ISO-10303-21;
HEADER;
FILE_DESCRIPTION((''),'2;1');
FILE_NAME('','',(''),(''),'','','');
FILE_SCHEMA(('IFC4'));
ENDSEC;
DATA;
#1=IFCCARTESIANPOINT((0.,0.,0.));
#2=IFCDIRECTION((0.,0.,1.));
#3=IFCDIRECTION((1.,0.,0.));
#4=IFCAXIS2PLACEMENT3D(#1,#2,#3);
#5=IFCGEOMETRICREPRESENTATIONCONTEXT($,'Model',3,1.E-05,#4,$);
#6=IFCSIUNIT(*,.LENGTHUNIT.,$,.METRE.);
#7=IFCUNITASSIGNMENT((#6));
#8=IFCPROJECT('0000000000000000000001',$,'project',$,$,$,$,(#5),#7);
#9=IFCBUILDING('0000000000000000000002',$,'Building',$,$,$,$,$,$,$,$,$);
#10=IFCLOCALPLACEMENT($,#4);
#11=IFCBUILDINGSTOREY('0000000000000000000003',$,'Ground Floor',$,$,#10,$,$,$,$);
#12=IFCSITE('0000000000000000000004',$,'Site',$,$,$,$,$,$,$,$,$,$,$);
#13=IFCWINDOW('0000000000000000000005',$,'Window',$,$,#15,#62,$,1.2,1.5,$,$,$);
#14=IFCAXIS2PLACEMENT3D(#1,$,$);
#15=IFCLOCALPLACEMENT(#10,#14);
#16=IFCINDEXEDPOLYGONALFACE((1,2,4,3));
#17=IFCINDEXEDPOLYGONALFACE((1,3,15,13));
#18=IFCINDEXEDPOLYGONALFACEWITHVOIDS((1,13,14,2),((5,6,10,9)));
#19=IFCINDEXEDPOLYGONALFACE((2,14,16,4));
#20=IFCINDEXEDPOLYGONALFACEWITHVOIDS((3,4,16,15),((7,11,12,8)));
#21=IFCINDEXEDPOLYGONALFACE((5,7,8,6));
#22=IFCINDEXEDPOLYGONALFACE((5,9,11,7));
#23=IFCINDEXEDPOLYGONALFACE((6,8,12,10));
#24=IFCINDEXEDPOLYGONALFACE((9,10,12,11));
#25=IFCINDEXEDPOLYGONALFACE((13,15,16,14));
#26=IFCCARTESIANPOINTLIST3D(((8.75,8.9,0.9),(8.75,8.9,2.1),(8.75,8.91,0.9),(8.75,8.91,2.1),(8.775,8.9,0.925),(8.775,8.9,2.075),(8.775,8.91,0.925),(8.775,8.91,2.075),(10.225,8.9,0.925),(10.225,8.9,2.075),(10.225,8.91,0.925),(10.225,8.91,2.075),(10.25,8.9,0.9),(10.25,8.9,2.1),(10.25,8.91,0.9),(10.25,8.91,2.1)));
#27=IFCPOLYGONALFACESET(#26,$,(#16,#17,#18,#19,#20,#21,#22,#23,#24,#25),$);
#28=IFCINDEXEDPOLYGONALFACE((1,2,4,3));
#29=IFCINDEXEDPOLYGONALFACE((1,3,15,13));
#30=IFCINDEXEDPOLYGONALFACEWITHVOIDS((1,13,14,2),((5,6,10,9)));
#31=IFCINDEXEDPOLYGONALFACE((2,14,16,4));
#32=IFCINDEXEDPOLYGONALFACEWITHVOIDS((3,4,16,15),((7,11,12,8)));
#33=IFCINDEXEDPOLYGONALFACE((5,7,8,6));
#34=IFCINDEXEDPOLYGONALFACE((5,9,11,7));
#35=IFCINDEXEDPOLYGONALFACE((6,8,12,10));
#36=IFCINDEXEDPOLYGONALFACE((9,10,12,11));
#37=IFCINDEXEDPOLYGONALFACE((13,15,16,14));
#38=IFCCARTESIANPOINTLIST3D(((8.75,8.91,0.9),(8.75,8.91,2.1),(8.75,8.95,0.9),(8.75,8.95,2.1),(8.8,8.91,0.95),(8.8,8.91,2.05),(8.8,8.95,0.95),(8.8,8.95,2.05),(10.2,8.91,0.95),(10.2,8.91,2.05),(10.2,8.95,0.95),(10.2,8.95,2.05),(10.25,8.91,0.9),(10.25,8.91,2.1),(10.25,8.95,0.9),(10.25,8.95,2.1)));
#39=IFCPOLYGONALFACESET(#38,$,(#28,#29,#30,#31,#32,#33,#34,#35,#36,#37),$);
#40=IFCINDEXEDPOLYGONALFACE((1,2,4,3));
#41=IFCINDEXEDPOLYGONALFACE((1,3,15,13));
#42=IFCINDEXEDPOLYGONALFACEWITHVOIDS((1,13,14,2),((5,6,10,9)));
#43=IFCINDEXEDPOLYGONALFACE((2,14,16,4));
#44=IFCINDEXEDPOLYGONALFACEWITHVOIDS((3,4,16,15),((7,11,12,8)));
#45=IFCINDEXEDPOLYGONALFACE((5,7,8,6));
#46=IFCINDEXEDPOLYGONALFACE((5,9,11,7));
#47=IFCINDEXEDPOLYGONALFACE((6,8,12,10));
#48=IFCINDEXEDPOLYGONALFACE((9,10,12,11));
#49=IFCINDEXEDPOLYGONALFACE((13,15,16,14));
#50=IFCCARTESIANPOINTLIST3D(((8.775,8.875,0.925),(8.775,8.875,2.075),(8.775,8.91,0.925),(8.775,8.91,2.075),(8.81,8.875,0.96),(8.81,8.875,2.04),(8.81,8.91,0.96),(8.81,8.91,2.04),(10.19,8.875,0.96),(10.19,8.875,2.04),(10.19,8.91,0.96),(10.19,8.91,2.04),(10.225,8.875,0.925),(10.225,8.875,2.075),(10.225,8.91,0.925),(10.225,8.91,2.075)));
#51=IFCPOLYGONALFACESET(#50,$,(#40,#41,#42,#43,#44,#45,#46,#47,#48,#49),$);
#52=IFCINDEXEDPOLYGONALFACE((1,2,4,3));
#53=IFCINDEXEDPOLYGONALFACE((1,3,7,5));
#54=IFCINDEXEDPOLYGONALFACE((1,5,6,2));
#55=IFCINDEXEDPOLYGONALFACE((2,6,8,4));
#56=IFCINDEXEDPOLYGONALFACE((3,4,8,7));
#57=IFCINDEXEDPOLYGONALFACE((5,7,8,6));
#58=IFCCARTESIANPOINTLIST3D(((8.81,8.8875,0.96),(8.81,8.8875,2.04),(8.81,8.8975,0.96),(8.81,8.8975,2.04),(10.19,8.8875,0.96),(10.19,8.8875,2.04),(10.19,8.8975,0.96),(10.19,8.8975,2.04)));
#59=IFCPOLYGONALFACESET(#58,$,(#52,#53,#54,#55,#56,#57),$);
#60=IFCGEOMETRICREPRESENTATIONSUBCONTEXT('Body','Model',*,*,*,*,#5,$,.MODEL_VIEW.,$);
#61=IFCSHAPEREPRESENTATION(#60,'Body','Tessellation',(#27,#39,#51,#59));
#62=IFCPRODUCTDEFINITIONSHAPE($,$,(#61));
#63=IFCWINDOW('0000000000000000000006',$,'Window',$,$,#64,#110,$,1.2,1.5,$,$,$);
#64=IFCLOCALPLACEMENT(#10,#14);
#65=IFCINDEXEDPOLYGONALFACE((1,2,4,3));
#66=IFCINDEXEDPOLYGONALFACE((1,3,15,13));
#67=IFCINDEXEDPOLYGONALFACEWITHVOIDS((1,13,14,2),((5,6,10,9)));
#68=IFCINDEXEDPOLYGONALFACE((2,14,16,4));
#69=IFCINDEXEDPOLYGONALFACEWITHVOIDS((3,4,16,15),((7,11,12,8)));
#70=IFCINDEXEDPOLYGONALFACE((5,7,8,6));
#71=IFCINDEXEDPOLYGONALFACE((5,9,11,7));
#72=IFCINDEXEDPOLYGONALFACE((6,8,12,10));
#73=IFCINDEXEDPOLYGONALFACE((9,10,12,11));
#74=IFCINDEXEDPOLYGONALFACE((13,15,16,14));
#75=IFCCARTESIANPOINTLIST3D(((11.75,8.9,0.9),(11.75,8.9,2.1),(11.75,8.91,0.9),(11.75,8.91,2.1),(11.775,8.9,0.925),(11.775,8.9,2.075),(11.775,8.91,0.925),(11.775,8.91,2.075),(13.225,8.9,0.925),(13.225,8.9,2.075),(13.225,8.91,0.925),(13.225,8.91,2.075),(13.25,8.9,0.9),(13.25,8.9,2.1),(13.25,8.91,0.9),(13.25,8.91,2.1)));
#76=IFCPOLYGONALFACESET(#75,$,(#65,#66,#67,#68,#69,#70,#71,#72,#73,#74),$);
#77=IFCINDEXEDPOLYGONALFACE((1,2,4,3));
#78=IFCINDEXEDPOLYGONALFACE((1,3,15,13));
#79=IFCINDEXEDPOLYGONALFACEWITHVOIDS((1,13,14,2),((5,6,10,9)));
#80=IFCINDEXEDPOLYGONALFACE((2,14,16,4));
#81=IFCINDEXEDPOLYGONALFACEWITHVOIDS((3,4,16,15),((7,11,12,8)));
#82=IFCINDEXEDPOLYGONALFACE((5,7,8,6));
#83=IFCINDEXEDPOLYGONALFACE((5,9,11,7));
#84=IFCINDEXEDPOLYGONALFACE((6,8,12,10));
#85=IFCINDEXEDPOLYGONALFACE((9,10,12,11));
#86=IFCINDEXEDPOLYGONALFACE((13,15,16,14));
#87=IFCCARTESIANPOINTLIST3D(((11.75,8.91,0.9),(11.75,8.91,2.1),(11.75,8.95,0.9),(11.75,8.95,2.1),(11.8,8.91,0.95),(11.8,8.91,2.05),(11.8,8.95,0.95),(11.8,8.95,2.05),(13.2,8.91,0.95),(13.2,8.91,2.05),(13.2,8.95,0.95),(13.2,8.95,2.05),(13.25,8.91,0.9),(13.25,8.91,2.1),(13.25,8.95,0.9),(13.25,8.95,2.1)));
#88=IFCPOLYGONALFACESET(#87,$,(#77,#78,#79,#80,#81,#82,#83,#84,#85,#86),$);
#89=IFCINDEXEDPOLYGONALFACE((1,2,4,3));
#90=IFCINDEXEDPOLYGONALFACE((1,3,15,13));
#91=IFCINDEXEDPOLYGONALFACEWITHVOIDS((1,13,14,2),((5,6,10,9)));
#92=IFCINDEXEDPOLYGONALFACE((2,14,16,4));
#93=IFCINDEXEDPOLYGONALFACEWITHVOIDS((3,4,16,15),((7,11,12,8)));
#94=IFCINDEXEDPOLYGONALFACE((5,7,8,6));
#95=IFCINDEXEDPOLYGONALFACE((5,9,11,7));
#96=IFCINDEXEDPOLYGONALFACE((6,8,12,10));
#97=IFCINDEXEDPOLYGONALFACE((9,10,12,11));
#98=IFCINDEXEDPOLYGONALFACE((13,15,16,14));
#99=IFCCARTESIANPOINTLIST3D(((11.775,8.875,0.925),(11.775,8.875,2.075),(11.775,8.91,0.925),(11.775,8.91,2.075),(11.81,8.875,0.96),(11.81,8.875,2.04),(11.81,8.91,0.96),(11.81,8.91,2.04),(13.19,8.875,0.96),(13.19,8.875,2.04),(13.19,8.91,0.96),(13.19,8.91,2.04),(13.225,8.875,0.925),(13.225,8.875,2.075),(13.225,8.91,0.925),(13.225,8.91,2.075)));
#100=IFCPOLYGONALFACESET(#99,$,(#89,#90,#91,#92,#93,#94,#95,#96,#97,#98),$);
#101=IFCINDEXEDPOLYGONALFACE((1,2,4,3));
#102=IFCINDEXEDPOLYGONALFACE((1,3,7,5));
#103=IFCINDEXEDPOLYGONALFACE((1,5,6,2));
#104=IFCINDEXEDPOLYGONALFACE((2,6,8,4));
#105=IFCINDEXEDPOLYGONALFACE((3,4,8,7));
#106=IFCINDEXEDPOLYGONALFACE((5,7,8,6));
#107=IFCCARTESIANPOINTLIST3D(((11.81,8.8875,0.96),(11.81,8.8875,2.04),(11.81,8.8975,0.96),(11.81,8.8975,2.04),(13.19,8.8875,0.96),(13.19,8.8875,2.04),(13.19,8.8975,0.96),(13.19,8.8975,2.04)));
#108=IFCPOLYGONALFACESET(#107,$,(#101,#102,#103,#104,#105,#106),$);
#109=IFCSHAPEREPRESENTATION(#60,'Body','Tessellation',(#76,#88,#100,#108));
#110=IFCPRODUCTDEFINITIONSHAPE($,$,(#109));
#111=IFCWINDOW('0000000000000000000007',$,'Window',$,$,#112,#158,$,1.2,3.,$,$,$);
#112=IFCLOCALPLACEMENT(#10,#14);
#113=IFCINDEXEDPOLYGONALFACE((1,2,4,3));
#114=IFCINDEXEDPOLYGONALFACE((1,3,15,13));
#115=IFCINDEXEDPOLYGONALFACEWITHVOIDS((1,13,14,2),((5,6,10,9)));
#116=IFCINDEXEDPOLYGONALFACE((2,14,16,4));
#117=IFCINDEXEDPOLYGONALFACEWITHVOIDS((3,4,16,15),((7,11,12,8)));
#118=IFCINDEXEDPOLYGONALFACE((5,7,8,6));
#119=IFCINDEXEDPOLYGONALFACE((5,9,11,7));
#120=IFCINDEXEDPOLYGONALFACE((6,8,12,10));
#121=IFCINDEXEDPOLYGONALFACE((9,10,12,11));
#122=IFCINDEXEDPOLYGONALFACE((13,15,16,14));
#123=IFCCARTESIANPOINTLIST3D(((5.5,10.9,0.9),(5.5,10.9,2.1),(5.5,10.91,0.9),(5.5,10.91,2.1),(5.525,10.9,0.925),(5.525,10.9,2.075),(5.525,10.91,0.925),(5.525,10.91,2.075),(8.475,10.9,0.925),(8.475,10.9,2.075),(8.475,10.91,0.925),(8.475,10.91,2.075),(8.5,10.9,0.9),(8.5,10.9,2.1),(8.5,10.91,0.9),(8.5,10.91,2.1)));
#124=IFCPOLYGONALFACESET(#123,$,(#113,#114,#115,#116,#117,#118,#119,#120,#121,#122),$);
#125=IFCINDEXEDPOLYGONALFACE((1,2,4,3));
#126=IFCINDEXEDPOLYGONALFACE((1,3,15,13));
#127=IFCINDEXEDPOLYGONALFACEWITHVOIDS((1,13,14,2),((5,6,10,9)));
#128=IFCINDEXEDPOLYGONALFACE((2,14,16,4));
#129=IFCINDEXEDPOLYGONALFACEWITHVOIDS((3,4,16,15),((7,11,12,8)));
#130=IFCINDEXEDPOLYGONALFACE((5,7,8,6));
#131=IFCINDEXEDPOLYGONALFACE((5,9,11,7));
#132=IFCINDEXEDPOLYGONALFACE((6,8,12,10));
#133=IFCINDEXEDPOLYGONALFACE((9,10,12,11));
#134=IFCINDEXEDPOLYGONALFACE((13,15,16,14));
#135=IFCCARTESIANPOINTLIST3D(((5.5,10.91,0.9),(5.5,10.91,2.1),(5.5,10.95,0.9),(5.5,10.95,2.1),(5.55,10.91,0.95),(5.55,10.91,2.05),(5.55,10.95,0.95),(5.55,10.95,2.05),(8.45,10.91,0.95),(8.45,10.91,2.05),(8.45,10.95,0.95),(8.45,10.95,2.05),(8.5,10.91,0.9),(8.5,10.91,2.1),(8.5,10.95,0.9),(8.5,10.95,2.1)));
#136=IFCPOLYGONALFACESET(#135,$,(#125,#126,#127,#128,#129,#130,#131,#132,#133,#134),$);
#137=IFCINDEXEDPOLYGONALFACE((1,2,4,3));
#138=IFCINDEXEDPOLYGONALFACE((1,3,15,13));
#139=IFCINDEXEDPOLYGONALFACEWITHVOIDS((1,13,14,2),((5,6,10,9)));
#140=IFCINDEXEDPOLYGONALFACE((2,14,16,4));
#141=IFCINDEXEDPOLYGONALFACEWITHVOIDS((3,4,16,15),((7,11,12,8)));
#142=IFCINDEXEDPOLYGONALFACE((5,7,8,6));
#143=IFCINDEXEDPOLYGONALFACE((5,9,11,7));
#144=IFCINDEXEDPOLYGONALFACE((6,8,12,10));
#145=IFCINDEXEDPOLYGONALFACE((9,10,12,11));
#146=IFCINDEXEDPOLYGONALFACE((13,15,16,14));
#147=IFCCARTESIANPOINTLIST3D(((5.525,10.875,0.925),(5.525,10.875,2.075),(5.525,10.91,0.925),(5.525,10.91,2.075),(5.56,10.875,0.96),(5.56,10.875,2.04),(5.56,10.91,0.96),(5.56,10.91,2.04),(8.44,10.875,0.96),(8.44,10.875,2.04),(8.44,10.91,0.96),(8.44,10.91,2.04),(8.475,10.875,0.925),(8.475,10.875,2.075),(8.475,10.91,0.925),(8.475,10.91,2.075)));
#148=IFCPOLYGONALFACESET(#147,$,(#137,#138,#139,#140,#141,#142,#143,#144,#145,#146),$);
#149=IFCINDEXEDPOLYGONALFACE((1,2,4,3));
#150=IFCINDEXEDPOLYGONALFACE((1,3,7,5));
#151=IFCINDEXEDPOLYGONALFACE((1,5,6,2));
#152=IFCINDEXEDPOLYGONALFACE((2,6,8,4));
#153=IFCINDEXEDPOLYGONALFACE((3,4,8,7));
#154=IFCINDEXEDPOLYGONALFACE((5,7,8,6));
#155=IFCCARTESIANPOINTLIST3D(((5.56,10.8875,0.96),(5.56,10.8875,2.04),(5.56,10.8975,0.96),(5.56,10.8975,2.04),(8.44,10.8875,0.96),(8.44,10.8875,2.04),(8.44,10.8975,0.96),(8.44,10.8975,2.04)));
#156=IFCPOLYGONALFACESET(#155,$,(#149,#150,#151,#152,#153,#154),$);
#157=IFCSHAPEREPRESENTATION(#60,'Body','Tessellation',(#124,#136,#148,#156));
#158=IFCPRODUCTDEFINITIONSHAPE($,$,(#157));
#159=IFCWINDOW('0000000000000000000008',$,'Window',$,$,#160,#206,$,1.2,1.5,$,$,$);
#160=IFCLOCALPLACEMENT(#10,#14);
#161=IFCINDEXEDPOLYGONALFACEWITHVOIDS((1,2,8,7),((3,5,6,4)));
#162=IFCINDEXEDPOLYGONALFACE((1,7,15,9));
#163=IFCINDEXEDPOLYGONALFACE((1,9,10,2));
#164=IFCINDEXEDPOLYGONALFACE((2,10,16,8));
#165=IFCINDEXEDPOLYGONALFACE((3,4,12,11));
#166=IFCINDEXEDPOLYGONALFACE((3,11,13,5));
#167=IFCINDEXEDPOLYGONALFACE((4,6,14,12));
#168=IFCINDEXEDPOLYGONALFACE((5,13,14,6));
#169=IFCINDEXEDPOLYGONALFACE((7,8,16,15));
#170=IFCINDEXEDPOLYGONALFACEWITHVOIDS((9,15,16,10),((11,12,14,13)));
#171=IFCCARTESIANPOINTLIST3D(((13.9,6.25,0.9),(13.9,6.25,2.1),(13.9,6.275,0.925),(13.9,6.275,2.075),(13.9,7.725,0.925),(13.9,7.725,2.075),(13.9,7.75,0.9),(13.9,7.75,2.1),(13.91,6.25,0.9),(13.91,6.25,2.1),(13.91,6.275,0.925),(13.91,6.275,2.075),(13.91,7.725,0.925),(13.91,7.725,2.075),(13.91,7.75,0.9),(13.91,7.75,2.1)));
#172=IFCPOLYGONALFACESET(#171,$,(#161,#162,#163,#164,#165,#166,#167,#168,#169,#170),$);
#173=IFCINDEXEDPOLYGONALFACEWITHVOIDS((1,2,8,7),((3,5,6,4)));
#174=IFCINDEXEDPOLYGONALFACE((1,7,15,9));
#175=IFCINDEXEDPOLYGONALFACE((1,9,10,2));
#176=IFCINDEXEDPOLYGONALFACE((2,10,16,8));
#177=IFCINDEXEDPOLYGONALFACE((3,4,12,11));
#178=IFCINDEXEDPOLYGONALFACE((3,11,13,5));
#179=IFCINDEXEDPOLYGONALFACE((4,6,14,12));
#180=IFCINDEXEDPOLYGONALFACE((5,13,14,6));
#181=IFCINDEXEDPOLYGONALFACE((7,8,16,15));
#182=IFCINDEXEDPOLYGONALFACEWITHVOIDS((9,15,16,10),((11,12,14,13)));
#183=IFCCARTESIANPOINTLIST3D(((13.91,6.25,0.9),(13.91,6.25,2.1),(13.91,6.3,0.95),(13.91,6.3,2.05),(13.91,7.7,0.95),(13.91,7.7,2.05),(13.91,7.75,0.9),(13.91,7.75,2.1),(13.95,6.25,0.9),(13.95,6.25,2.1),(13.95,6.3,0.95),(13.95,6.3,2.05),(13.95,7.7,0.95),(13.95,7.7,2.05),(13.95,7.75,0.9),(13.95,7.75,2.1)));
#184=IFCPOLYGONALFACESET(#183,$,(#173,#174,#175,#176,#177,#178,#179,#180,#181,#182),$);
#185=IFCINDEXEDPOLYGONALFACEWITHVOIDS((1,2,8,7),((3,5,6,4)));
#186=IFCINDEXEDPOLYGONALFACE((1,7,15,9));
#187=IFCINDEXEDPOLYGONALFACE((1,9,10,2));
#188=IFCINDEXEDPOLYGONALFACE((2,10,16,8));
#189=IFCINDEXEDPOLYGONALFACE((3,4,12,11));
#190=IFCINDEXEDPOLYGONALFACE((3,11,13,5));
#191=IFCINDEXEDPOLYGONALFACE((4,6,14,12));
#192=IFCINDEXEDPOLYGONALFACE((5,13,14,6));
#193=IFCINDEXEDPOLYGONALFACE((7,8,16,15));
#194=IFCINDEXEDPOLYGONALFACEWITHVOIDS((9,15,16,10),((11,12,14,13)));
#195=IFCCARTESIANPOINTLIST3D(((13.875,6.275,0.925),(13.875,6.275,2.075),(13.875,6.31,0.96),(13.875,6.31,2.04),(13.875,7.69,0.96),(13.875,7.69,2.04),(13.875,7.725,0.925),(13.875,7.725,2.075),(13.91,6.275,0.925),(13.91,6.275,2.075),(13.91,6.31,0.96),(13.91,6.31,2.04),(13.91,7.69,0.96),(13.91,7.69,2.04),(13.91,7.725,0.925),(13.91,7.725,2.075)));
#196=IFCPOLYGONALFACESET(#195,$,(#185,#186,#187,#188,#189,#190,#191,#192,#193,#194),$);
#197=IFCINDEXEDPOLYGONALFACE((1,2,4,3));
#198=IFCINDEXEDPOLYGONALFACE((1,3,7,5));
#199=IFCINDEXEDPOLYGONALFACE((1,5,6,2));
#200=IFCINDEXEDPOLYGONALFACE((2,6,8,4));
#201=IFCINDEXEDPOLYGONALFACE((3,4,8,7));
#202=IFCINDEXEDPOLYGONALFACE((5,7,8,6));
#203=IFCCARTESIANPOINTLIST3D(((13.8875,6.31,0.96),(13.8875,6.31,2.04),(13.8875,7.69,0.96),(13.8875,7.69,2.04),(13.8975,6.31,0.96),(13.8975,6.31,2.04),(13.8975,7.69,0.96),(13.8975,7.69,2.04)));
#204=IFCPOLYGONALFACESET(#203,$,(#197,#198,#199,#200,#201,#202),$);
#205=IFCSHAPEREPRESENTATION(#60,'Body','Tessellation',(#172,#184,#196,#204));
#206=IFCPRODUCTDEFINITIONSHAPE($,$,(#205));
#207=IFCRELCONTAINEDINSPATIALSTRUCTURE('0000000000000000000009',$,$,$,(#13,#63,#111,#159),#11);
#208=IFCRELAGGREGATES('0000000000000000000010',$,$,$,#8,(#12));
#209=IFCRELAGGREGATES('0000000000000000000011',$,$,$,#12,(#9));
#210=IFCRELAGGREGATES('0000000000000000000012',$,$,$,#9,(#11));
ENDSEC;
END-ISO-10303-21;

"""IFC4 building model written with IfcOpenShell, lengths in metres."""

from ifc_helpers import new_model, si_unit, frame, origin_with_axes, place, context, subcontext, project, spatial, line, indexed_curve, outline, extrude, element, save


model = new_model("IFC4")

# Units and contexts
model_context = context("Model", 3, precision=1e-05, world=origin_with_axes())
body_context = subcontext(model_context, "Body", "Model", "MODEL_VIEW")
ifc_project = project(units=[si_unit("LENGTHUNIT", "METRE")], contexts=[model_context])

# Site, building, storey
site = spatial("IfcSite", under=ifc_project, Name="Site")
building = spatial("IfcBuilding", under=site, Name="Building")
storey_placement = place(None, origin_with_axes())
storey = spatial("IfcBuildingStorey", under=building, at=storey_placement, Name="Ground Floor")

# Windows
for number, where, z_axis, x_axis, name in (
    (1, (10.25, 9.0, 0.9), (0.0, 0.0, 1.0), (-1.0, 0.0, 0.0), "Window"),
    (2, (13.25, 9.0, 0.9), (0.0, 0.0, 1.0), (-1.0, 0.0, 0.0), "Window"),
):
    element("IfcWindow", number, at=place(storey_placement, frame(where, z_axis=z_axis, x_axis=x_axis)), inside=storey, Name=name, OverallHeight=1.2, OverallWidth=1.5, context=body_context, shape_type="SweptSolid", body=[
        extrude(outline(indexed_curve([(0.0, 0.0), (1.5, 0.0), (1.5, 1.2), (0.0, 1.2)], segments=[line(1, 2, 3, 4, 1)]), holes=[indexed_curve([(0.025, 0.025), (1.475, 0.025), (1.475, 1.175), (0.025, 1.175)], segments=[line(1, 2, 3, 4, 1)])]), frame((0.0, 0.09, 0.0), z_axis=(0.0, -1.0, 0.0), x_axis=(1.0, 0.0, 0.0)), (0.0, 0.0, -1.0), 0.01),
        extrude(outline(indexed_curve([(0.0, 0.0), (1.5, 0.0), (1.5, 1.2), (0.0, 1.2)], segments=[line(1, 2, 3, 4, 1)]), holes=[indexed_curve([(0.05, 0.05), (1.45, 0.05), (1.45, 1.15), (0.05, 1.15)], segments=[line(1, 2, 3, 4, 1)])]), frame((0.0, 0.05, 0.0), z_axis=(0.0, -1.0, 0.0), x_axis=(1.0, 0.0, 0.0)), (0.0, 0.0, -1.0), 0.04),
        extrude(outline(indexed_curve([(0.0, 0.0), (1.45, 0.0), (1.45, 1.15), (0.0, 1.15)], segments=[line(1, 2, 3, 4, 1)]), holes=[indexed_curve([(0.035, 0.035), (1.415, 0.035), (1.415, 1.115), (0.035, 1.115)], segments=[line(1, 2, 3, 4, 1)])]), frame((0.025, 0.09, 0.025), z_axis=(0.0, -1.0, 0.0), x_axis=(1.0, 0.0, 0.0)), (0.0, 0.0, -1.0), 0.035),
        extrude(outline(indexed_curve([(0.035, 0.035), (1.415, 0.035), (1.415, 1.115), (0.035, 1.115)], segments=[line(1, 2, 3, 4, 1)])), frame((0.025, 0.1025, 0.025), z_axis=(0.0, -1.0, 0.0), x_axis=(1.0, 0.0, 0.0)), (0.0, 0.0, -1.0), 0.01),
    ])
window_1_placement = place(storey_placement, frame((8.5, 11.0, 0.9), z_axis=(0.0, 0.0, 1.0), x_axis=(-1.0, 0.0, 0.0)))
element("IfcWindow", 3, at=window_1_placement, inside=storey, Name="Window", OverallHeight=1.2, OverallWidth=3.0, context=body_context, shape_type="SweptSolid", body=[
    extrude(outline(indexed_curve([(0.0, 0.0), (3.0, 0.0), (3.0, 1.2), (0.0, 1.2)], segments=[line(1, 2, 3, 4, 1)]), holes=[indexed_curve([(0.025, 0.025), (2.975, 0.025), (2.975, 1.175), (0.025, 1.175)], segments=[line(1, 2, 3, 4, 1)])]), frame((0.0, 0.09, 0.0), z_axis=(0.0, -1.0, 0.0), x_axis=(1.0, 0.0, 0.0)), (0.0, 0.0, -1.0), 0.01),
    extrude(outline(indexed_curve([(0.0, 0.0), (3.0, 0.0), (3.0, 1.2), (0.0, 1.2)], segments=[line(1, 2, 3, 4, 1)]), holes=[indexed_curve([(0.05, 0.05), (2.95, 0.05), (2.95, 1.15), (0.05, 1.15)], segments=[line(1, 2, 3, 4, 1)])]), frame((0.0, 0.05, 0.0), z_axis=(0.0, -1.0, 0.0), x_axis=(1.0, 0.0, 0.0)), (0.0, 0.0, -1.0), 0.04),
    extrude(outline(indexed_curve([(0.0, 0.0), (2.95, 0.0), (2.95, 1.15), (0.0, 1.15)], segments=[line(1, 2, 3, 4, 1)]), holes=[indexed_curve([(0.035, 0.035), (2.915, 0.035), (2.915, 1.115), (0.035, 1.115)], segments=[line(1, 2, 3, 4, 1)])]), frame((0.025, 0.09, 0.025), z_axis=(0.0, -1.0, 0.0), x_axis=(1.0, 0.0, 0.0)), (0.0, 0.0, -1.0), 0.035),
    extrude(outline(indexed_curve([(0.035, 0.035), (2.915, 0.035), (2.915, 1.115), (0.035, 1.115)], segments=[line(1, 2, 3, 4, 1)])), frame((0.025, 0.1025, 0.025), z_axis=(0.0, -1.0, 0.0), x_axis=(1.0, 0.0, 0.0)), (0.0, 0.0, -1.0), 0.01),
])
window_2_placement = place(storey_placement, frame((14.0, 6.25, 0.9), z_axis=(0.0, 0.0, 1.0), x_axis=(0.0, 1.0, 0.0)))
element("IfcWindow", 4, at=window_2_placement, inside=storey, Name="Window", OverallHeight=1.2, OverallWidth=1.5, context=body_context, shape_type="SweptSolid", body=[
    extrude(outline(indexed_curve([(0.0, 0.0), (1.5, 0.0), (1.5, 1.2), (0.0, 1.2)], segments=[line(1, 2, 3, 4, 1)]), holes=[indexed_curve([(0.025, 0.025), (1.475, 0.025), (1.475, 1.175), (0.025, 1.175)], segments=[line(1, 2, 3, 4, 1)])]), frame((0.0, 0.09, 0.0), z_axis=(0.0, -1.0, 0.0), x_axis=(1.0, 0.0, 0.0)), (0.0, 0.0, -1.0), 0.01),
    extrude(outline(indexed_curve([(0.0, 0.0), (1.5, 0.0), (1.5, 1.2), (0.0, 1.2)], segments=[line(1, 2, 3, 4, 1)]), holes=[indexed_curve([(0.05, 0.05), (1.45, 0.05), (1.45, 1.15), (0.05, 1.15)], segments=[line(1, 2, 3, 4, 1)])]), frame((0.0, 0.05, 0.0), z_axis=(0.0, -1.0, 0.0), x_axis=(1.0, 0.0, 0.0)), (0.0, 0.0, -1.0), 0.04),
    extrude(outline(indexed_curve([(0.0, 0.0), (1.45, 0.0), (1.45, 1.15), (0.0, 1.15)], segments=[line(1, 2, 3, 4, 1)]), holes=[indexed_curve([(0.035, 0.035), (1.415, 0.035), (1.415, 1.115), (0.035, 1.115)], segments=[line(1, 2, 3, 4, 1)])]), frame((0.025, 0.09, 0.025), z_axis=(0.0, -1.0, 0.0), x_axis=(1.0, 0.0, 0.0)), (0.0, 0.0, -1.0), 0.035),
    extrude(outline(indexed_curve([(0.035, 0.035), (1.415, 0.035), (1.415, 1.115), (0.035, 1.115)], segments=[line(1, 2, 3, 4, 1)])), frame((0.025, 0.1025, 0.025), z_axis=(0.0, -1.0, 0.0), x_axis=(1.0, 0.0, 0.0)), (0.0, 0.0, -1.0), 0.01),
])

save(model, "model.ifc")
